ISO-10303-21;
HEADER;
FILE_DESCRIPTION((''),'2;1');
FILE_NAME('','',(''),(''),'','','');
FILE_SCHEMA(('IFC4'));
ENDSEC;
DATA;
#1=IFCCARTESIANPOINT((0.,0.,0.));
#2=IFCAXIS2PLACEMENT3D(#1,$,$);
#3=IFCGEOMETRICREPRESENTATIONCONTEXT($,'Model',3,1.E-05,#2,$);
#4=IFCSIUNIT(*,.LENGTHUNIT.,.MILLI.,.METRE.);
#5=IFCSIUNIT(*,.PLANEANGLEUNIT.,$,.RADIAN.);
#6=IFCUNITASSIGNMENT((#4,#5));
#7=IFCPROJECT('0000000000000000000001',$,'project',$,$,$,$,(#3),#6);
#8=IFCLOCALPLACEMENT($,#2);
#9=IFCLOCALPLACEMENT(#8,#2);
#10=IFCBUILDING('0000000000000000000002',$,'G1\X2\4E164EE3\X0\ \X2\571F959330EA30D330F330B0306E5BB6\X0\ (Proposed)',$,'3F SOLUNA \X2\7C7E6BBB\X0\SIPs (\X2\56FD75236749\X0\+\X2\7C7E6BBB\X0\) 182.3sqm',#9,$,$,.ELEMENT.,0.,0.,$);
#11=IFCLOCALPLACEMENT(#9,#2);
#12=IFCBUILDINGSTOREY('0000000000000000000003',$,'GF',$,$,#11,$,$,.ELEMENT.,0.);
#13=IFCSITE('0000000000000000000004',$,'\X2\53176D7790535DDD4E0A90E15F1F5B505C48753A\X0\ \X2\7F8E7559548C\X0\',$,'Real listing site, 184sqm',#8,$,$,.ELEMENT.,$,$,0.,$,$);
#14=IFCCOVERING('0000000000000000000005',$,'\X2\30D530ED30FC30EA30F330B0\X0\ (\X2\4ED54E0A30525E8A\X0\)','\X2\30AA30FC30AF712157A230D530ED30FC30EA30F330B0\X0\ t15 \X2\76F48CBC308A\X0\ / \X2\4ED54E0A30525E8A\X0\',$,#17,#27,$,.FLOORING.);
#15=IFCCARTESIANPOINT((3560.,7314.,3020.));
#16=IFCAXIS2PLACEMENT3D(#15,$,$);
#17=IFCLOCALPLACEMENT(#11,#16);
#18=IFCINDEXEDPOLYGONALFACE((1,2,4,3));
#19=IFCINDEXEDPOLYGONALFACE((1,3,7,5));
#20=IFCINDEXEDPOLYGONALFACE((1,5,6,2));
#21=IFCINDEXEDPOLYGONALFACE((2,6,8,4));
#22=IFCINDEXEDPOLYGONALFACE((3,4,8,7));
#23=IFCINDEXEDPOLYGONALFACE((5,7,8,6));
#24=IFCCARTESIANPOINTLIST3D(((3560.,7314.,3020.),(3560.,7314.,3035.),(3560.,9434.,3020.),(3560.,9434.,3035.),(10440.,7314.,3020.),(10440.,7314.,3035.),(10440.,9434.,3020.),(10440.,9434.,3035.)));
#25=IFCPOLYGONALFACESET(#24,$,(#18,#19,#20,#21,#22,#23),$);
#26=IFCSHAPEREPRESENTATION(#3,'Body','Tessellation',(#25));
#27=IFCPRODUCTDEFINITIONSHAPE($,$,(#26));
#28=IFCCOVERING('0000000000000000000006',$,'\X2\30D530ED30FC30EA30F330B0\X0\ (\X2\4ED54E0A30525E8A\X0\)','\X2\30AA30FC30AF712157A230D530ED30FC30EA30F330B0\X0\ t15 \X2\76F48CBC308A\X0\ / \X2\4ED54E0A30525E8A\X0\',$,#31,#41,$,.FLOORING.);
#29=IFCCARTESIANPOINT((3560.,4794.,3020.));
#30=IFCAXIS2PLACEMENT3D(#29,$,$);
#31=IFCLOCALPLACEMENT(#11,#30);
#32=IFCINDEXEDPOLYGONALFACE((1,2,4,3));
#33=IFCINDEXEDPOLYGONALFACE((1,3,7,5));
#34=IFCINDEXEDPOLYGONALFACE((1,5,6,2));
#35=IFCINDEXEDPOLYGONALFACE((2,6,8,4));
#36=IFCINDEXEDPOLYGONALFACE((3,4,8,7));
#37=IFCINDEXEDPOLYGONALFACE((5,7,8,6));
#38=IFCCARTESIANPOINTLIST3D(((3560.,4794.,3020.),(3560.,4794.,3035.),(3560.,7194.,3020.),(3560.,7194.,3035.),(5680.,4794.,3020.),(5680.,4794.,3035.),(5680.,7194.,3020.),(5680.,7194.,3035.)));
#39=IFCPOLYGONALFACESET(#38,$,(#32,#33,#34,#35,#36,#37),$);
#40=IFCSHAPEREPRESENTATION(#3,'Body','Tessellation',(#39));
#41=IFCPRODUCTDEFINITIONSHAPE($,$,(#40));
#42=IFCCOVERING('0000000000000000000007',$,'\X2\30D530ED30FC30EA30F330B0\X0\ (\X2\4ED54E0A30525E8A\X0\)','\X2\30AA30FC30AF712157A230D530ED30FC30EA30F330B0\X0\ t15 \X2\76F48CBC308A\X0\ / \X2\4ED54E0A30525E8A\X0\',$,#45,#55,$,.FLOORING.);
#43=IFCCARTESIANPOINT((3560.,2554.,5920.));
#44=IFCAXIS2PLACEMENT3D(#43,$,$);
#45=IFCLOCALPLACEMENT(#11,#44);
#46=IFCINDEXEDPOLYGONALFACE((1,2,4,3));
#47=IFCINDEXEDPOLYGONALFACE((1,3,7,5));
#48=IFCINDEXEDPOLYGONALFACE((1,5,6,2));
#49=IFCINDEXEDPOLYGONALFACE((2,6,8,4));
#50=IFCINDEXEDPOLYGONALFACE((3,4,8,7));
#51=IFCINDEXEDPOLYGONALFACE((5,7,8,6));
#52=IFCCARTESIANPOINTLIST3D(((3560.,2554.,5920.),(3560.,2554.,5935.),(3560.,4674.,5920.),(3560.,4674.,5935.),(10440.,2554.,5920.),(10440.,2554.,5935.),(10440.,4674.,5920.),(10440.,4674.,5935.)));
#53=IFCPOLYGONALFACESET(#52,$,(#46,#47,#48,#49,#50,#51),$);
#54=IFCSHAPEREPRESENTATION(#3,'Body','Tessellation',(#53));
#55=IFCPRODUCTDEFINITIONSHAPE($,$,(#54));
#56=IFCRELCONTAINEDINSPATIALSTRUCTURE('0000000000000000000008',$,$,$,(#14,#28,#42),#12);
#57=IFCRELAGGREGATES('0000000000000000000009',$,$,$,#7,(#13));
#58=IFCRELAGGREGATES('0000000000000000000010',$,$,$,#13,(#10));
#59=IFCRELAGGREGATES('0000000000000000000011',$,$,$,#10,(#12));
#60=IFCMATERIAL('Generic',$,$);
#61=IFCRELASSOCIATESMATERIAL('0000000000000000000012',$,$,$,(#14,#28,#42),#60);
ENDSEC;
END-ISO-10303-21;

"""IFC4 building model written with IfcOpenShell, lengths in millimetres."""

from ifc_helpers import new_model, si_unit, frame, frame_2d, origin, place, context, project, spatial, rectangle, extrude, material, element, save


model = new_model("IFC4")

# Units and contexts
model_context = context("Model", 3, precision=1e-05, world=origin())
ifc_project = project(units=[si_unit("LENGTHUNIT", "METRE", prefix="MILLI"), si_unit("PLANEANGLEUNIT", "RADIAN")], contexts=[model_context])

# Site, building, storey
site_placement = place(None, origin())
site = spatial("IfcSite", under=ifc_project, at=site_placement, Name="北海道川上郡弟子屈町 美留和", ObjectType="Real listing site, 184sqm", CompositionType="ELEMENT", RefElevation=0.0)
building_placement = place(site_placement, origin())
building = spatial("IfcBuilding", under=site, at=building_placement, Name="G1世代 土間リビングの家 (Proposed)", ObjectType="3F SOLUNA 籾殻SIPs (国産杉+籾殻) 182.3sqm", CompositionType="ELEMENT", ElevationOfRefHeight=0.0, ElevationOfTerrain=0.0)
storey_placement = place(building_placement, origin())
storey = spatial("IfcBuildingStorey", under=building, at=storey_placement, Name="GF", CompositionType="ELEMENT", Elevation=0.0)

# Shared definitions
ifc_material_1 = material(Name="Generic")

# Coverings
covering_1_placement = place(storey_placement, frame((3560.0, 7314.0, 3020.0)))
element("IfcCovering", 1, at=covering_1_placement, inside=storey, material=ifc_material_1, Name="フローリング (仕上げ床)", Description="オーク無垢フローリング t15 直貼り / 仕上げ床", PredefinedType="FLOORING", context=model_context, shape_type="SweptSolid", body=[
    extrude(rectangle(XDim=6880.0, YDim=2120.0, at=frame_2d((3440.0, 1060.0))), frame((3560.0, 7314.0, 3020.0)), (0.0, 0.0, 1.0), 15.0),
])
covering_2_placement = place(storey_placement, frame((3560.0, 4794.0, 3020.0)))
element("IfcCovering", 2, at=covering_2_placement, inside=storey, material=ifc_material_1, Name="フローリング (仕上げ床)", Description="オーク無垢フローリング t15 直貼り / 仕上げ床", PredefinedType="FLOORING", context=model_context, shape_type="SweptSolid", body=[
    extrude(rectangle(XDim=2120.0, YDim=2400.0, at=frame_2d((1060.0, 1200.0))), frame((3560.0, 4794.0, 3020.0)), (0.0, 0.0, 1.0), 15.0),
])
covering_3_placement = place(storey_placement, frame((3560.0, 2554.0, 5920.0)))
element("IfcCovering", 3, at=covering_3_placement, inside=storey, material=ifc_material_1, Name="フローリング (仕上げ床)", Description="オーク無垢フローリング t15 直貼り / 仕上げ床", PredefinedType="FLOORING", context=model_context, shape_type="SweptSolid", body=[
    extrude(rectangle(XDim=6880.0, YDim=2120.0, at=frame_2d((3440.0, 1060.0))), frame((3560.0, 2554.0, 5920.0)), (0.0, 0.0, 1.0), 15.0),
])

save(model, "model.ifc")
